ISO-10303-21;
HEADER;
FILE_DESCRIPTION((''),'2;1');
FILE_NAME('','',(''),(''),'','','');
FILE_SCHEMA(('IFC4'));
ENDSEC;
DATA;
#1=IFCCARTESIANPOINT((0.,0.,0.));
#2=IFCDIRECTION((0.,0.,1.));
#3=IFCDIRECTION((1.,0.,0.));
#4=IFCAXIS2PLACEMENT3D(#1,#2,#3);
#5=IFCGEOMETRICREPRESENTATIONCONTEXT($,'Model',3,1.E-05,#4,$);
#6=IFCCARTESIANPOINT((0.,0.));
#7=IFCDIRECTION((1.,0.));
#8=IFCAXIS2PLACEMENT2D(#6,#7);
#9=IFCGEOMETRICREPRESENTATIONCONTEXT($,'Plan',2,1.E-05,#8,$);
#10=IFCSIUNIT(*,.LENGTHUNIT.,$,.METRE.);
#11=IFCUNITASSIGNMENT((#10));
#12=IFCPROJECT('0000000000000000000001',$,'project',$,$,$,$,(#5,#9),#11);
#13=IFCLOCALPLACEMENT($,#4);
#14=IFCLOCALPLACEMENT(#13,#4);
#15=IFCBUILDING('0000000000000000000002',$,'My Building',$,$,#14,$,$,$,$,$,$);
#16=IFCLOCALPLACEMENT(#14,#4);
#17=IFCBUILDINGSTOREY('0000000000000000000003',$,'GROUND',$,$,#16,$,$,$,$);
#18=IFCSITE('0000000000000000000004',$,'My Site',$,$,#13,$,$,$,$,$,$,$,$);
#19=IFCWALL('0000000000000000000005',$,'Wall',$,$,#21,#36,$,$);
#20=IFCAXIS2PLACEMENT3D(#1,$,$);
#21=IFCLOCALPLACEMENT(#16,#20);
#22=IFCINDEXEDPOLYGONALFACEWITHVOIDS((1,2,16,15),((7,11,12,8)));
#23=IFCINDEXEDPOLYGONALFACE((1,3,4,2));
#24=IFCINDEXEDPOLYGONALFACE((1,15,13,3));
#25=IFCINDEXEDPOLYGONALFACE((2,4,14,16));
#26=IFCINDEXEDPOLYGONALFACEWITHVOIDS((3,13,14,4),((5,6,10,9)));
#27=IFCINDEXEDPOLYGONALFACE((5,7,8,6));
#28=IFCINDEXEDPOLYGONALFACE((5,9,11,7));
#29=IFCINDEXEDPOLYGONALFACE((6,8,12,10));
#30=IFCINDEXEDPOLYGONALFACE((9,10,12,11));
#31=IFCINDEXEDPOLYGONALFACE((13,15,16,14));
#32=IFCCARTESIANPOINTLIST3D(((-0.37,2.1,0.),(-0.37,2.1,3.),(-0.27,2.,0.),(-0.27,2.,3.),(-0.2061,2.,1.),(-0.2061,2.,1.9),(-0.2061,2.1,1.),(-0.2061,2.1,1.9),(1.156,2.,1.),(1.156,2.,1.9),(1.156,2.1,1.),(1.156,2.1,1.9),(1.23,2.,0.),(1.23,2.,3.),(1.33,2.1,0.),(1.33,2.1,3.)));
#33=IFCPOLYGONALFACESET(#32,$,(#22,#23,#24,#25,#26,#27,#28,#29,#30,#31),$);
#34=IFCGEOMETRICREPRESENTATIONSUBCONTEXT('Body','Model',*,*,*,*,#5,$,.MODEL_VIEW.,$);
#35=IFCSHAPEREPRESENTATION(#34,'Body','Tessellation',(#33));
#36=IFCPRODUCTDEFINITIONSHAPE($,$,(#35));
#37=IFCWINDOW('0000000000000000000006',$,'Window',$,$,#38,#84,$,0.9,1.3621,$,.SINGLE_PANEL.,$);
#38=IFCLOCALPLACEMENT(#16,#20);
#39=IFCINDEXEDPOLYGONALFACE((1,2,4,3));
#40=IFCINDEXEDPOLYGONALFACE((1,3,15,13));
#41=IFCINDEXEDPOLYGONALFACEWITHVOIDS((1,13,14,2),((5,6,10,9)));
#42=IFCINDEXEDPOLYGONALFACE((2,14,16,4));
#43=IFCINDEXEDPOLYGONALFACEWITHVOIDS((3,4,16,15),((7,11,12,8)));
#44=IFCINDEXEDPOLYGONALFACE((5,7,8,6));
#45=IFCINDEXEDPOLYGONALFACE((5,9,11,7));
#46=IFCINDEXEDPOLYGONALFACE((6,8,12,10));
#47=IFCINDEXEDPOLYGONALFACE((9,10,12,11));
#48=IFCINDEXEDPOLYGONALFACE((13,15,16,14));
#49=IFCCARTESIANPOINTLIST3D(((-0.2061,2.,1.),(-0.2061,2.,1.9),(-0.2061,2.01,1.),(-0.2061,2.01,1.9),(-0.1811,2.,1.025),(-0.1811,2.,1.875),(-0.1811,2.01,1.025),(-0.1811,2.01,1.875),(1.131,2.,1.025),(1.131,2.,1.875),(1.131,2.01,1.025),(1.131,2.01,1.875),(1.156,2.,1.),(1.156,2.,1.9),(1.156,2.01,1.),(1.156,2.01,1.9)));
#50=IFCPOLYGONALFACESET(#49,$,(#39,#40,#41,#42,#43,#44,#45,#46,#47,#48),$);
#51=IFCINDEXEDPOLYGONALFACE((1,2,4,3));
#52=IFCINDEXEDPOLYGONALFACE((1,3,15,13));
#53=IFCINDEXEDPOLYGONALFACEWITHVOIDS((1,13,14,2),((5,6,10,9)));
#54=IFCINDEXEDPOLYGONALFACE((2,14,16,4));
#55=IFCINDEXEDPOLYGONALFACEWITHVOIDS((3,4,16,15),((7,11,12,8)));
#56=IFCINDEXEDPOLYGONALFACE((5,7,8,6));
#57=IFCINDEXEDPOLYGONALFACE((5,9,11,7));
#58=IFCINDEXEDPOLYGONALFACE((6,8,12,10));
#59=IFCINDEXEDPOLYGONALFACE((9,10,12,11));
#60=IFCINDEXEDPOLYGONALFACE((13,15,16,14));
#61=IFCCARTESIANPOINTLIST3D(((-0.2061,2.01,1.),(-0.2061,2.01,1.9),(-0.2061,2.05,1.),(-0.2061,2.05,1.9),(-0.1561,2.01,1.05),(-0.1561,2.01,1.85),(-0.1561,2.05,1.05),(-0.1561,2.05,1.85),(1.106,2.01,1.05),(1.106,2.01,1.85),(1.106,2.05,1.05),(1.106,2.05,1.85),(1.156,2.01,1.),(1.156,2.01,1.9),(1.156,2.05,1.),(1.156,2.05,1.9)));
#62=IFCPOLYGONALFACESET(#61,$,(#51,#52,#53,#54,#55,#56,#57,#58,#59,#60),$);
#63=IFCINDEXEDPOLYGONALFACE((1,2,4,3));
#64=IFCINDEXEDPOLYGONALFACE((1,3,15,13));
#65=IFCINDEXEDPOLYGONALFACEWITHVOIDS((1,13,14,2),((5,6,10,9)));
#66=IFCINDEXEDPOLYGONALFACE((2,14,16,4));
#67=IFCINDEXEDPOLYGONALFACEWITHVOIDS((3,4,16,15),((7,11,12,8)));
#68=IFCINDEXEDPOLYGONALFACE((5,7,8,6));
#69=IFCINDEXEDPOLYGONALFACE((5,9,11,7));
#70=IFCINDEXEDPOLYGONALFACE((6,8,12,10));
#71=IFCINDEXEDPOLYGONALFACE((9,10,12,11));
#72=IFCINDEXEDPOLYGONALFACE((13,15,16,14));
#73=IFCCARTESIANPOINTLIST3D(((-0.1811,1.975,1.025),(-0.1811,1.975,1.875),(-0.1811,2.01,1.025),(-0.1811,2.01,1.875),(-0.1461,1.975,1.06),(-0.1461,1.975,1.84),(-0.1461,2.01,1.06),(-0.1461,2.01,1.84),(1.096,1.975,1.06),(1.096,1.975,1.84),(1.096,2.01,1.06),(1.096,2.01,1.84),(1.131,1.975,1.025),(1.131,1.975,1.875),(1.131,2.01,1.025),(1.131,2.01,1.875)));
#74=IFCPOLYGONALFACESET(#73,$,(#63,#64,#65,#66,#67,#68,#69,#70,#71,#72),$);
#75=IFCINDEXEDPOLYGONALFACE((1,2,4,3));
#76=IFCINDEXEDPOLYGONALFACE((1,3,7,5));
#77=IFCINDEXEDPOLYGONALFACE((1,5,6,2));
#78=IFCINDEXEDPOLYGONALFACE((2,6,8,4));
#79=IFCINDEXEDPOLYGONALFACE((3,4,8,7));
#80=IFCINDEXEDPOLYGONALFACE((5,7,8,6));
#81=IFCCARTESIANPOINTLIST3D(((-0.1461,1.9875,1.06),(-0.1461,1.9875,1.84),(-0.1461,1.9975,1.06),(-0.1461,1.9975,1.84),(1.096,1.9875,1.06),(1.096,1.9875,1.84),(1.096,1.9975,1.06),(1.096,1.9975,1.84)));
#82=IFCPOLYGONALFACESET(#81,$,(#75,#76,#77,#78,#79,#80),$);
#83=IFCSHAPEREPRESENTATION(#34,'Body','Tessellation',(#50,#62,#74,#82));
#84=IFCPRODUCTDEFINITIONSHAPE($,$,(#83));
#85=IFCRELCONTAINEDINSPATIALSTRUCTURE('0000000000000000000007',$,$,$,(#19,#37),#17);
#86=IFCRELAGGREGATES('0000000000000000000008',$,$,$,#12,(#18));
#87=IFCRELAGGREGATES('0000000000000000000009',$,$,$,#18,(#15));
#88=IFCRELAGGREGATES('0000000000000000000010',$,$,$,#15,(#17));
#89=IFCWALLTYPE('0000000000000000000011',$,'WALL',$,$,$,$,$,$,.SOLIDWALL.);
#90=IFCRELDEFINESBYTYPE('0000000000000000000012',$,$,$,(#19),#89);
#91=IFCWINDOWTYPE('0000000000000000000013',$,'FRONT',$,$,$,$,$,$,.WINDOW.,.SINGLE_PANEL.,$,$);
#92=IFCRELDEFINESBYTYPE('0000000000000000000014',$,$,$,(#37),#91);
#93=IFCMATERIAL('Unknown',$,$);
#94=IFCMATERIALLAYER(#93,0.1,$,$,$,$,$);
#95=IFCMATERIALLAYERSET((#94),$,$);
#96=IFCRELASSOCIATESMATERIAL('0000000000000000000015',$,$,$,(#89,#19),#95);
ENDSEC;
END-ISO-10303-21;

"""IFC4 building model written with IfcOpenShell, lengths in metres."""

from ifc_helpers import new_model, entity, si_unit, frame, origin_with_axes, origin_2d_with_axis, place, context, subcontext, project, spatial, line, indexed_curve, outline, extrude, shape, source, transform, mapped, material, layer, layer_set, layer_usage, type_object, type_shapes, element, fill, save


model = new_model("IFC4")

# Units and contexts
model_context = context("Model", 3, precision=1e-05, world=origin_with_axes())
plan_context = context("Plan", 2, precision=1e-05, world=origin_2d_with_axis())
body_context_1 = subcontext(model_context, "Body", "Model", "MODEL_VIEW")
body_context_2 = subcontext(plan_context, "Body", "Plan", "PLAN_VIEW")
ifc_project = project(units=[si_unit("LENGTHUNIT", "METRE")], contexts=[model_context, plan_context])

# Site, building, storey
site_placement = place(None, origin_with_axes())
site = spatial("IfcSite", under=ifc_project, at=site_placement, Name="My Site")
building_placement = place(site_placement, origin_with_axes())
building = spatial("IfcBuilding", under=site, at=building_placement, Name="My Building")
storey_placement = place(building_placement, origin_with_axes())
storey = spatial("IfcBuildingStorey", under=building, at=storey_placement, Name="GROUND")

# Wall, opening, window
ifc_material_1 = material(Name="Unknown")
ifc_layer_1 = layer(ifc_material_1, 0.1)
ifc_layer_set_1 = layer_set([ifc_layer_1])
wall_type = type_object("IfcWallType", Name="WALL", PredefinedType="SOLIDWALL", material=ifc_layer_set_1)
ifc_layer_usage_1 = layer_usage(ifc_layer_set_1, "AXIS2", "POSITIVE", 0.0)
wall_1_placement = place(storey_placement, frame((-0.27, 2.0, 0.0), z_axis=(0.0, 0.0, 1.0), x_axis=(1.0, 0.0, 0.0)))
wall_1 = element("IfcWall", 1, at=wall_1_placement, inside=storey, type_object=wall_type, material=ifc_layer_usage_1, Name="Wall", context=body_context_1, shape_type="SweptSolid", body=[
    extrude(outline(indexed_curve([(0.0, 0.0), (-0.1, 0.1), (1.6, 0.1), (1.5, 0.0)], segments=[line(1, 2, 3, 4, 1)])), origin_with_axes(), (0.0, 0.0, 1.0), 3.0),
])
shared_shape_1 = source(origin_with_axes(), body_context_1, "Body", "SweptSolid", [
    extrude(outline(indexed_curve([(0.0, 0.0), (1.3621, 0.0), (1.3621, 0.9), (0.0, 0.9)], segments=[line(1, 2, 3, 4, 1)])), frame((0.0, -0.6, 0.0), z_axis=(0.0, -1.0, 0.0), x_axis=(1.0, 0.0, 0.0)), (0.0, 0.0, -1.0), 1.2),
])
opening_1_placement = place(wall_1_placement, frame((1.426, 0.1, 1.0), z_axis=(0.0, 0.0, 1.0), x_axis=(-1.0, 0.0, 0.0)))
opening_1 = element("IfcOpeningElement", 2, at=opening_1_placement, cuts=wall_1, PredefinedType="OPENING", context=body_context_1, shape_type="MappedRepresentation", body=[
    mapped(shared_shape_1, transform((0.0, 0.0, 0.0), x_axis=(1.0, 0.0, 0.0), y_axis=(0.0, 1.0, 0.0), z_axis=(0.0, 0.0, 1.0), scale=1.0)),
])
window_type_1 = type_object("IfcWindowType", Name="FRONT", PartitioningType="SINGLE_PANEL", PredefinedType="WINDOW")
shared_shape_2 = source(origin_with_axes(), body_context_1, "Body", "SweptSolid", [
    extrude(outline(indexed_curve([(0.0, 0.0), (1.3621, 0.0), (1.3621, 0.9), (0.0, 0.9)], segments=[line(1, 2, 3, 4, 1)]), holes=[indexed_curve([(0.025, 0.025), (1.3371, 0.025), (1.3371, 0.875), (0.025, 0.875)], segments=[line(1, 2, 3, 4, 1)])]), frame((0.0, 0.09, 0.0), z_axis=(0.0, -1.0, 0.0), x_axis=(1.0, 0.0, 0.0)), (0.0, 0.0, -1.0), 0.01),
    extrude(outline(indexed_curve([(0.0, 0.0), (1.3621, 0.0), (1.3621, 0.9), (0.0, 0.9)], segments=[line(1, 2, 3, 4, 1)]), holes=[indexed_curve([(0.05, 0.05), (1.3121, 0.05), (1.3121, 0.85), (0.05, 0.85)], segments=[line(1, 2, 3, 4, 1)])]), frame((0.0, 0.05, 0.0), z_axis=(0.0, -1.0, 0.0), x_axis=(1.0, 0.0, 0.0)), (0.0, 0.0, -1.0), 0.04),
    extrude(outline(indexed_curve([(0.0, 0.0), (1.3121, 0.0), (1.3121, 0.85), (0.0, 0.85)], segments=[line(1, 2, 3, 4, 1)]), holes=[indexed_curve([(0.035, 0.035), (1.2771, 0.035), (1.2771, 0.815), (0.035, 0.815)], segments=[line(1, 2, 3, 4, 1)])]), frame((0.025, 0.09, 0.025), z_axis=(0.0, -1.0, 0.0), x_axis=(1.0, 0.0, 0.0)), (0.0, 0.0, -1.0), 0.035),
    extrude(outline(indexed_curve([(0.035, 0.035), (1.2771, 0.035), (1.2771, 0.815), (0.035, 0.815)], segments=[line(1, 2, 3, 4, 1)])), frame((0.025, 0.1025, 0.025), z_axis=(0.0, -1.0, 0.0), x_axis=(1.0, 0.0, 0.0)), (0.0, 0.0, -1.0), 0.01),
])
shared_shape_3 = source(origin_with_axes(), body_context_2, "Body", "Curve2D", [
    entity("IfcIndexedPolyCurve", entity("IfcCartesianPointList2D", [[0.05, 0.05], [1.3121, 0.05]])),
    entity("IfcIndexedPolyCurve", entity("IfcCartesianPointList2D", [[0.0, 0.1], [0.025, 0.1], [0.025, 0.09], [0.05, 0.09], [0.05, 0.05], [0.0, 0.05]]), [entity("IfcLineIndex", [1, 2, 3, 4, 5, 6, 1])]),
    entity("IfcIndexedPolyCurve", entity("IfcCartesianPointList2D", [[1.3621, 0.1], [1.3371, 0.1], [1.3371, 0.09], [1.3121, 0.09], [1.3121, 0.05], [1.3621, 0.05]]), [entity("IfcLineIndex", [1, 2, 3, 4, 5, 6, 1])]),
    entity("IfcIndexedPolyCurve", entity("IfcCartesianPointList2D", [[0.025, 0.09], [0.06, 0.09], [0.06, 0.125], [0.025, 0.125]]), [entity("IfcLineIndex", [1, 2, 3, 4, 1])]),
    entity("IfcIndexedPolyCurve", entity("IfcCartesianPointList2D", [[1.3371, 0.09], [1.3021, 0.09], [1.3021, 0.125], [1.3371, 0.125]]), [entity("IfcLineIndex", [1, 2, 3, 4, 1])]),
    entity("IfcIndexedPolyCurve", entity("IfcCartesianPointList2D", [[0.06, 0.09], [1.3021, 0.09]])),
    entity("IfcIndexedPolyCurve", entity("IfcCartesianPointList2D", [[0.06, 0.125], [1.3021, 0.125]])),
    entity("IfcIndexedPolyCurve", entity("IfcCartesianPointList2D", [[0.06, 0.1075], [1.3021, 0.1075]])),
])
type_shapes(window_type_1, [shared_shape_2, shared_shape_3])
window_1_placement = place(opening_1_placement, frame((0.0, 0.0, 0.0), z_axis=(0.0, 0.0, 1.0), x_axis=(1.0, 0.0, 0.0)))
window_1 = element("IfcWindow", 3, at=window_1_placement, inside=storey, type_object=window_type_1, Name="Window", OverallHeight=0.9, OverallWidth=1.3621, PartitioningType="SINGLE_PANEL", shapes=[
    shape(body_context_1, "Body", "MappedRepresentation", [mapped(shared_shape_2, transform((0.0, 0.0, 0.0), x_axis=(1.0, 0.0, 0.0), y_axis=(0.0, 1.0, 0.0), z_axis=(0.0, 0.0, 1.0), scale=1.0))]),
    shape(body_context_2, "Body", "MappedRepresentation", [mapped(shared_shape_3, transform((0.0, 0.0, 0.0), x_axis=(1.0, 0.0, 0.0), y_axis=(0.0, 1.0, 0.0), z_axis=(0.0, 0.0, 1.0), scale=1.0))]),
])
fill(opening_1, window_1)

save(model, "model.ifc")
